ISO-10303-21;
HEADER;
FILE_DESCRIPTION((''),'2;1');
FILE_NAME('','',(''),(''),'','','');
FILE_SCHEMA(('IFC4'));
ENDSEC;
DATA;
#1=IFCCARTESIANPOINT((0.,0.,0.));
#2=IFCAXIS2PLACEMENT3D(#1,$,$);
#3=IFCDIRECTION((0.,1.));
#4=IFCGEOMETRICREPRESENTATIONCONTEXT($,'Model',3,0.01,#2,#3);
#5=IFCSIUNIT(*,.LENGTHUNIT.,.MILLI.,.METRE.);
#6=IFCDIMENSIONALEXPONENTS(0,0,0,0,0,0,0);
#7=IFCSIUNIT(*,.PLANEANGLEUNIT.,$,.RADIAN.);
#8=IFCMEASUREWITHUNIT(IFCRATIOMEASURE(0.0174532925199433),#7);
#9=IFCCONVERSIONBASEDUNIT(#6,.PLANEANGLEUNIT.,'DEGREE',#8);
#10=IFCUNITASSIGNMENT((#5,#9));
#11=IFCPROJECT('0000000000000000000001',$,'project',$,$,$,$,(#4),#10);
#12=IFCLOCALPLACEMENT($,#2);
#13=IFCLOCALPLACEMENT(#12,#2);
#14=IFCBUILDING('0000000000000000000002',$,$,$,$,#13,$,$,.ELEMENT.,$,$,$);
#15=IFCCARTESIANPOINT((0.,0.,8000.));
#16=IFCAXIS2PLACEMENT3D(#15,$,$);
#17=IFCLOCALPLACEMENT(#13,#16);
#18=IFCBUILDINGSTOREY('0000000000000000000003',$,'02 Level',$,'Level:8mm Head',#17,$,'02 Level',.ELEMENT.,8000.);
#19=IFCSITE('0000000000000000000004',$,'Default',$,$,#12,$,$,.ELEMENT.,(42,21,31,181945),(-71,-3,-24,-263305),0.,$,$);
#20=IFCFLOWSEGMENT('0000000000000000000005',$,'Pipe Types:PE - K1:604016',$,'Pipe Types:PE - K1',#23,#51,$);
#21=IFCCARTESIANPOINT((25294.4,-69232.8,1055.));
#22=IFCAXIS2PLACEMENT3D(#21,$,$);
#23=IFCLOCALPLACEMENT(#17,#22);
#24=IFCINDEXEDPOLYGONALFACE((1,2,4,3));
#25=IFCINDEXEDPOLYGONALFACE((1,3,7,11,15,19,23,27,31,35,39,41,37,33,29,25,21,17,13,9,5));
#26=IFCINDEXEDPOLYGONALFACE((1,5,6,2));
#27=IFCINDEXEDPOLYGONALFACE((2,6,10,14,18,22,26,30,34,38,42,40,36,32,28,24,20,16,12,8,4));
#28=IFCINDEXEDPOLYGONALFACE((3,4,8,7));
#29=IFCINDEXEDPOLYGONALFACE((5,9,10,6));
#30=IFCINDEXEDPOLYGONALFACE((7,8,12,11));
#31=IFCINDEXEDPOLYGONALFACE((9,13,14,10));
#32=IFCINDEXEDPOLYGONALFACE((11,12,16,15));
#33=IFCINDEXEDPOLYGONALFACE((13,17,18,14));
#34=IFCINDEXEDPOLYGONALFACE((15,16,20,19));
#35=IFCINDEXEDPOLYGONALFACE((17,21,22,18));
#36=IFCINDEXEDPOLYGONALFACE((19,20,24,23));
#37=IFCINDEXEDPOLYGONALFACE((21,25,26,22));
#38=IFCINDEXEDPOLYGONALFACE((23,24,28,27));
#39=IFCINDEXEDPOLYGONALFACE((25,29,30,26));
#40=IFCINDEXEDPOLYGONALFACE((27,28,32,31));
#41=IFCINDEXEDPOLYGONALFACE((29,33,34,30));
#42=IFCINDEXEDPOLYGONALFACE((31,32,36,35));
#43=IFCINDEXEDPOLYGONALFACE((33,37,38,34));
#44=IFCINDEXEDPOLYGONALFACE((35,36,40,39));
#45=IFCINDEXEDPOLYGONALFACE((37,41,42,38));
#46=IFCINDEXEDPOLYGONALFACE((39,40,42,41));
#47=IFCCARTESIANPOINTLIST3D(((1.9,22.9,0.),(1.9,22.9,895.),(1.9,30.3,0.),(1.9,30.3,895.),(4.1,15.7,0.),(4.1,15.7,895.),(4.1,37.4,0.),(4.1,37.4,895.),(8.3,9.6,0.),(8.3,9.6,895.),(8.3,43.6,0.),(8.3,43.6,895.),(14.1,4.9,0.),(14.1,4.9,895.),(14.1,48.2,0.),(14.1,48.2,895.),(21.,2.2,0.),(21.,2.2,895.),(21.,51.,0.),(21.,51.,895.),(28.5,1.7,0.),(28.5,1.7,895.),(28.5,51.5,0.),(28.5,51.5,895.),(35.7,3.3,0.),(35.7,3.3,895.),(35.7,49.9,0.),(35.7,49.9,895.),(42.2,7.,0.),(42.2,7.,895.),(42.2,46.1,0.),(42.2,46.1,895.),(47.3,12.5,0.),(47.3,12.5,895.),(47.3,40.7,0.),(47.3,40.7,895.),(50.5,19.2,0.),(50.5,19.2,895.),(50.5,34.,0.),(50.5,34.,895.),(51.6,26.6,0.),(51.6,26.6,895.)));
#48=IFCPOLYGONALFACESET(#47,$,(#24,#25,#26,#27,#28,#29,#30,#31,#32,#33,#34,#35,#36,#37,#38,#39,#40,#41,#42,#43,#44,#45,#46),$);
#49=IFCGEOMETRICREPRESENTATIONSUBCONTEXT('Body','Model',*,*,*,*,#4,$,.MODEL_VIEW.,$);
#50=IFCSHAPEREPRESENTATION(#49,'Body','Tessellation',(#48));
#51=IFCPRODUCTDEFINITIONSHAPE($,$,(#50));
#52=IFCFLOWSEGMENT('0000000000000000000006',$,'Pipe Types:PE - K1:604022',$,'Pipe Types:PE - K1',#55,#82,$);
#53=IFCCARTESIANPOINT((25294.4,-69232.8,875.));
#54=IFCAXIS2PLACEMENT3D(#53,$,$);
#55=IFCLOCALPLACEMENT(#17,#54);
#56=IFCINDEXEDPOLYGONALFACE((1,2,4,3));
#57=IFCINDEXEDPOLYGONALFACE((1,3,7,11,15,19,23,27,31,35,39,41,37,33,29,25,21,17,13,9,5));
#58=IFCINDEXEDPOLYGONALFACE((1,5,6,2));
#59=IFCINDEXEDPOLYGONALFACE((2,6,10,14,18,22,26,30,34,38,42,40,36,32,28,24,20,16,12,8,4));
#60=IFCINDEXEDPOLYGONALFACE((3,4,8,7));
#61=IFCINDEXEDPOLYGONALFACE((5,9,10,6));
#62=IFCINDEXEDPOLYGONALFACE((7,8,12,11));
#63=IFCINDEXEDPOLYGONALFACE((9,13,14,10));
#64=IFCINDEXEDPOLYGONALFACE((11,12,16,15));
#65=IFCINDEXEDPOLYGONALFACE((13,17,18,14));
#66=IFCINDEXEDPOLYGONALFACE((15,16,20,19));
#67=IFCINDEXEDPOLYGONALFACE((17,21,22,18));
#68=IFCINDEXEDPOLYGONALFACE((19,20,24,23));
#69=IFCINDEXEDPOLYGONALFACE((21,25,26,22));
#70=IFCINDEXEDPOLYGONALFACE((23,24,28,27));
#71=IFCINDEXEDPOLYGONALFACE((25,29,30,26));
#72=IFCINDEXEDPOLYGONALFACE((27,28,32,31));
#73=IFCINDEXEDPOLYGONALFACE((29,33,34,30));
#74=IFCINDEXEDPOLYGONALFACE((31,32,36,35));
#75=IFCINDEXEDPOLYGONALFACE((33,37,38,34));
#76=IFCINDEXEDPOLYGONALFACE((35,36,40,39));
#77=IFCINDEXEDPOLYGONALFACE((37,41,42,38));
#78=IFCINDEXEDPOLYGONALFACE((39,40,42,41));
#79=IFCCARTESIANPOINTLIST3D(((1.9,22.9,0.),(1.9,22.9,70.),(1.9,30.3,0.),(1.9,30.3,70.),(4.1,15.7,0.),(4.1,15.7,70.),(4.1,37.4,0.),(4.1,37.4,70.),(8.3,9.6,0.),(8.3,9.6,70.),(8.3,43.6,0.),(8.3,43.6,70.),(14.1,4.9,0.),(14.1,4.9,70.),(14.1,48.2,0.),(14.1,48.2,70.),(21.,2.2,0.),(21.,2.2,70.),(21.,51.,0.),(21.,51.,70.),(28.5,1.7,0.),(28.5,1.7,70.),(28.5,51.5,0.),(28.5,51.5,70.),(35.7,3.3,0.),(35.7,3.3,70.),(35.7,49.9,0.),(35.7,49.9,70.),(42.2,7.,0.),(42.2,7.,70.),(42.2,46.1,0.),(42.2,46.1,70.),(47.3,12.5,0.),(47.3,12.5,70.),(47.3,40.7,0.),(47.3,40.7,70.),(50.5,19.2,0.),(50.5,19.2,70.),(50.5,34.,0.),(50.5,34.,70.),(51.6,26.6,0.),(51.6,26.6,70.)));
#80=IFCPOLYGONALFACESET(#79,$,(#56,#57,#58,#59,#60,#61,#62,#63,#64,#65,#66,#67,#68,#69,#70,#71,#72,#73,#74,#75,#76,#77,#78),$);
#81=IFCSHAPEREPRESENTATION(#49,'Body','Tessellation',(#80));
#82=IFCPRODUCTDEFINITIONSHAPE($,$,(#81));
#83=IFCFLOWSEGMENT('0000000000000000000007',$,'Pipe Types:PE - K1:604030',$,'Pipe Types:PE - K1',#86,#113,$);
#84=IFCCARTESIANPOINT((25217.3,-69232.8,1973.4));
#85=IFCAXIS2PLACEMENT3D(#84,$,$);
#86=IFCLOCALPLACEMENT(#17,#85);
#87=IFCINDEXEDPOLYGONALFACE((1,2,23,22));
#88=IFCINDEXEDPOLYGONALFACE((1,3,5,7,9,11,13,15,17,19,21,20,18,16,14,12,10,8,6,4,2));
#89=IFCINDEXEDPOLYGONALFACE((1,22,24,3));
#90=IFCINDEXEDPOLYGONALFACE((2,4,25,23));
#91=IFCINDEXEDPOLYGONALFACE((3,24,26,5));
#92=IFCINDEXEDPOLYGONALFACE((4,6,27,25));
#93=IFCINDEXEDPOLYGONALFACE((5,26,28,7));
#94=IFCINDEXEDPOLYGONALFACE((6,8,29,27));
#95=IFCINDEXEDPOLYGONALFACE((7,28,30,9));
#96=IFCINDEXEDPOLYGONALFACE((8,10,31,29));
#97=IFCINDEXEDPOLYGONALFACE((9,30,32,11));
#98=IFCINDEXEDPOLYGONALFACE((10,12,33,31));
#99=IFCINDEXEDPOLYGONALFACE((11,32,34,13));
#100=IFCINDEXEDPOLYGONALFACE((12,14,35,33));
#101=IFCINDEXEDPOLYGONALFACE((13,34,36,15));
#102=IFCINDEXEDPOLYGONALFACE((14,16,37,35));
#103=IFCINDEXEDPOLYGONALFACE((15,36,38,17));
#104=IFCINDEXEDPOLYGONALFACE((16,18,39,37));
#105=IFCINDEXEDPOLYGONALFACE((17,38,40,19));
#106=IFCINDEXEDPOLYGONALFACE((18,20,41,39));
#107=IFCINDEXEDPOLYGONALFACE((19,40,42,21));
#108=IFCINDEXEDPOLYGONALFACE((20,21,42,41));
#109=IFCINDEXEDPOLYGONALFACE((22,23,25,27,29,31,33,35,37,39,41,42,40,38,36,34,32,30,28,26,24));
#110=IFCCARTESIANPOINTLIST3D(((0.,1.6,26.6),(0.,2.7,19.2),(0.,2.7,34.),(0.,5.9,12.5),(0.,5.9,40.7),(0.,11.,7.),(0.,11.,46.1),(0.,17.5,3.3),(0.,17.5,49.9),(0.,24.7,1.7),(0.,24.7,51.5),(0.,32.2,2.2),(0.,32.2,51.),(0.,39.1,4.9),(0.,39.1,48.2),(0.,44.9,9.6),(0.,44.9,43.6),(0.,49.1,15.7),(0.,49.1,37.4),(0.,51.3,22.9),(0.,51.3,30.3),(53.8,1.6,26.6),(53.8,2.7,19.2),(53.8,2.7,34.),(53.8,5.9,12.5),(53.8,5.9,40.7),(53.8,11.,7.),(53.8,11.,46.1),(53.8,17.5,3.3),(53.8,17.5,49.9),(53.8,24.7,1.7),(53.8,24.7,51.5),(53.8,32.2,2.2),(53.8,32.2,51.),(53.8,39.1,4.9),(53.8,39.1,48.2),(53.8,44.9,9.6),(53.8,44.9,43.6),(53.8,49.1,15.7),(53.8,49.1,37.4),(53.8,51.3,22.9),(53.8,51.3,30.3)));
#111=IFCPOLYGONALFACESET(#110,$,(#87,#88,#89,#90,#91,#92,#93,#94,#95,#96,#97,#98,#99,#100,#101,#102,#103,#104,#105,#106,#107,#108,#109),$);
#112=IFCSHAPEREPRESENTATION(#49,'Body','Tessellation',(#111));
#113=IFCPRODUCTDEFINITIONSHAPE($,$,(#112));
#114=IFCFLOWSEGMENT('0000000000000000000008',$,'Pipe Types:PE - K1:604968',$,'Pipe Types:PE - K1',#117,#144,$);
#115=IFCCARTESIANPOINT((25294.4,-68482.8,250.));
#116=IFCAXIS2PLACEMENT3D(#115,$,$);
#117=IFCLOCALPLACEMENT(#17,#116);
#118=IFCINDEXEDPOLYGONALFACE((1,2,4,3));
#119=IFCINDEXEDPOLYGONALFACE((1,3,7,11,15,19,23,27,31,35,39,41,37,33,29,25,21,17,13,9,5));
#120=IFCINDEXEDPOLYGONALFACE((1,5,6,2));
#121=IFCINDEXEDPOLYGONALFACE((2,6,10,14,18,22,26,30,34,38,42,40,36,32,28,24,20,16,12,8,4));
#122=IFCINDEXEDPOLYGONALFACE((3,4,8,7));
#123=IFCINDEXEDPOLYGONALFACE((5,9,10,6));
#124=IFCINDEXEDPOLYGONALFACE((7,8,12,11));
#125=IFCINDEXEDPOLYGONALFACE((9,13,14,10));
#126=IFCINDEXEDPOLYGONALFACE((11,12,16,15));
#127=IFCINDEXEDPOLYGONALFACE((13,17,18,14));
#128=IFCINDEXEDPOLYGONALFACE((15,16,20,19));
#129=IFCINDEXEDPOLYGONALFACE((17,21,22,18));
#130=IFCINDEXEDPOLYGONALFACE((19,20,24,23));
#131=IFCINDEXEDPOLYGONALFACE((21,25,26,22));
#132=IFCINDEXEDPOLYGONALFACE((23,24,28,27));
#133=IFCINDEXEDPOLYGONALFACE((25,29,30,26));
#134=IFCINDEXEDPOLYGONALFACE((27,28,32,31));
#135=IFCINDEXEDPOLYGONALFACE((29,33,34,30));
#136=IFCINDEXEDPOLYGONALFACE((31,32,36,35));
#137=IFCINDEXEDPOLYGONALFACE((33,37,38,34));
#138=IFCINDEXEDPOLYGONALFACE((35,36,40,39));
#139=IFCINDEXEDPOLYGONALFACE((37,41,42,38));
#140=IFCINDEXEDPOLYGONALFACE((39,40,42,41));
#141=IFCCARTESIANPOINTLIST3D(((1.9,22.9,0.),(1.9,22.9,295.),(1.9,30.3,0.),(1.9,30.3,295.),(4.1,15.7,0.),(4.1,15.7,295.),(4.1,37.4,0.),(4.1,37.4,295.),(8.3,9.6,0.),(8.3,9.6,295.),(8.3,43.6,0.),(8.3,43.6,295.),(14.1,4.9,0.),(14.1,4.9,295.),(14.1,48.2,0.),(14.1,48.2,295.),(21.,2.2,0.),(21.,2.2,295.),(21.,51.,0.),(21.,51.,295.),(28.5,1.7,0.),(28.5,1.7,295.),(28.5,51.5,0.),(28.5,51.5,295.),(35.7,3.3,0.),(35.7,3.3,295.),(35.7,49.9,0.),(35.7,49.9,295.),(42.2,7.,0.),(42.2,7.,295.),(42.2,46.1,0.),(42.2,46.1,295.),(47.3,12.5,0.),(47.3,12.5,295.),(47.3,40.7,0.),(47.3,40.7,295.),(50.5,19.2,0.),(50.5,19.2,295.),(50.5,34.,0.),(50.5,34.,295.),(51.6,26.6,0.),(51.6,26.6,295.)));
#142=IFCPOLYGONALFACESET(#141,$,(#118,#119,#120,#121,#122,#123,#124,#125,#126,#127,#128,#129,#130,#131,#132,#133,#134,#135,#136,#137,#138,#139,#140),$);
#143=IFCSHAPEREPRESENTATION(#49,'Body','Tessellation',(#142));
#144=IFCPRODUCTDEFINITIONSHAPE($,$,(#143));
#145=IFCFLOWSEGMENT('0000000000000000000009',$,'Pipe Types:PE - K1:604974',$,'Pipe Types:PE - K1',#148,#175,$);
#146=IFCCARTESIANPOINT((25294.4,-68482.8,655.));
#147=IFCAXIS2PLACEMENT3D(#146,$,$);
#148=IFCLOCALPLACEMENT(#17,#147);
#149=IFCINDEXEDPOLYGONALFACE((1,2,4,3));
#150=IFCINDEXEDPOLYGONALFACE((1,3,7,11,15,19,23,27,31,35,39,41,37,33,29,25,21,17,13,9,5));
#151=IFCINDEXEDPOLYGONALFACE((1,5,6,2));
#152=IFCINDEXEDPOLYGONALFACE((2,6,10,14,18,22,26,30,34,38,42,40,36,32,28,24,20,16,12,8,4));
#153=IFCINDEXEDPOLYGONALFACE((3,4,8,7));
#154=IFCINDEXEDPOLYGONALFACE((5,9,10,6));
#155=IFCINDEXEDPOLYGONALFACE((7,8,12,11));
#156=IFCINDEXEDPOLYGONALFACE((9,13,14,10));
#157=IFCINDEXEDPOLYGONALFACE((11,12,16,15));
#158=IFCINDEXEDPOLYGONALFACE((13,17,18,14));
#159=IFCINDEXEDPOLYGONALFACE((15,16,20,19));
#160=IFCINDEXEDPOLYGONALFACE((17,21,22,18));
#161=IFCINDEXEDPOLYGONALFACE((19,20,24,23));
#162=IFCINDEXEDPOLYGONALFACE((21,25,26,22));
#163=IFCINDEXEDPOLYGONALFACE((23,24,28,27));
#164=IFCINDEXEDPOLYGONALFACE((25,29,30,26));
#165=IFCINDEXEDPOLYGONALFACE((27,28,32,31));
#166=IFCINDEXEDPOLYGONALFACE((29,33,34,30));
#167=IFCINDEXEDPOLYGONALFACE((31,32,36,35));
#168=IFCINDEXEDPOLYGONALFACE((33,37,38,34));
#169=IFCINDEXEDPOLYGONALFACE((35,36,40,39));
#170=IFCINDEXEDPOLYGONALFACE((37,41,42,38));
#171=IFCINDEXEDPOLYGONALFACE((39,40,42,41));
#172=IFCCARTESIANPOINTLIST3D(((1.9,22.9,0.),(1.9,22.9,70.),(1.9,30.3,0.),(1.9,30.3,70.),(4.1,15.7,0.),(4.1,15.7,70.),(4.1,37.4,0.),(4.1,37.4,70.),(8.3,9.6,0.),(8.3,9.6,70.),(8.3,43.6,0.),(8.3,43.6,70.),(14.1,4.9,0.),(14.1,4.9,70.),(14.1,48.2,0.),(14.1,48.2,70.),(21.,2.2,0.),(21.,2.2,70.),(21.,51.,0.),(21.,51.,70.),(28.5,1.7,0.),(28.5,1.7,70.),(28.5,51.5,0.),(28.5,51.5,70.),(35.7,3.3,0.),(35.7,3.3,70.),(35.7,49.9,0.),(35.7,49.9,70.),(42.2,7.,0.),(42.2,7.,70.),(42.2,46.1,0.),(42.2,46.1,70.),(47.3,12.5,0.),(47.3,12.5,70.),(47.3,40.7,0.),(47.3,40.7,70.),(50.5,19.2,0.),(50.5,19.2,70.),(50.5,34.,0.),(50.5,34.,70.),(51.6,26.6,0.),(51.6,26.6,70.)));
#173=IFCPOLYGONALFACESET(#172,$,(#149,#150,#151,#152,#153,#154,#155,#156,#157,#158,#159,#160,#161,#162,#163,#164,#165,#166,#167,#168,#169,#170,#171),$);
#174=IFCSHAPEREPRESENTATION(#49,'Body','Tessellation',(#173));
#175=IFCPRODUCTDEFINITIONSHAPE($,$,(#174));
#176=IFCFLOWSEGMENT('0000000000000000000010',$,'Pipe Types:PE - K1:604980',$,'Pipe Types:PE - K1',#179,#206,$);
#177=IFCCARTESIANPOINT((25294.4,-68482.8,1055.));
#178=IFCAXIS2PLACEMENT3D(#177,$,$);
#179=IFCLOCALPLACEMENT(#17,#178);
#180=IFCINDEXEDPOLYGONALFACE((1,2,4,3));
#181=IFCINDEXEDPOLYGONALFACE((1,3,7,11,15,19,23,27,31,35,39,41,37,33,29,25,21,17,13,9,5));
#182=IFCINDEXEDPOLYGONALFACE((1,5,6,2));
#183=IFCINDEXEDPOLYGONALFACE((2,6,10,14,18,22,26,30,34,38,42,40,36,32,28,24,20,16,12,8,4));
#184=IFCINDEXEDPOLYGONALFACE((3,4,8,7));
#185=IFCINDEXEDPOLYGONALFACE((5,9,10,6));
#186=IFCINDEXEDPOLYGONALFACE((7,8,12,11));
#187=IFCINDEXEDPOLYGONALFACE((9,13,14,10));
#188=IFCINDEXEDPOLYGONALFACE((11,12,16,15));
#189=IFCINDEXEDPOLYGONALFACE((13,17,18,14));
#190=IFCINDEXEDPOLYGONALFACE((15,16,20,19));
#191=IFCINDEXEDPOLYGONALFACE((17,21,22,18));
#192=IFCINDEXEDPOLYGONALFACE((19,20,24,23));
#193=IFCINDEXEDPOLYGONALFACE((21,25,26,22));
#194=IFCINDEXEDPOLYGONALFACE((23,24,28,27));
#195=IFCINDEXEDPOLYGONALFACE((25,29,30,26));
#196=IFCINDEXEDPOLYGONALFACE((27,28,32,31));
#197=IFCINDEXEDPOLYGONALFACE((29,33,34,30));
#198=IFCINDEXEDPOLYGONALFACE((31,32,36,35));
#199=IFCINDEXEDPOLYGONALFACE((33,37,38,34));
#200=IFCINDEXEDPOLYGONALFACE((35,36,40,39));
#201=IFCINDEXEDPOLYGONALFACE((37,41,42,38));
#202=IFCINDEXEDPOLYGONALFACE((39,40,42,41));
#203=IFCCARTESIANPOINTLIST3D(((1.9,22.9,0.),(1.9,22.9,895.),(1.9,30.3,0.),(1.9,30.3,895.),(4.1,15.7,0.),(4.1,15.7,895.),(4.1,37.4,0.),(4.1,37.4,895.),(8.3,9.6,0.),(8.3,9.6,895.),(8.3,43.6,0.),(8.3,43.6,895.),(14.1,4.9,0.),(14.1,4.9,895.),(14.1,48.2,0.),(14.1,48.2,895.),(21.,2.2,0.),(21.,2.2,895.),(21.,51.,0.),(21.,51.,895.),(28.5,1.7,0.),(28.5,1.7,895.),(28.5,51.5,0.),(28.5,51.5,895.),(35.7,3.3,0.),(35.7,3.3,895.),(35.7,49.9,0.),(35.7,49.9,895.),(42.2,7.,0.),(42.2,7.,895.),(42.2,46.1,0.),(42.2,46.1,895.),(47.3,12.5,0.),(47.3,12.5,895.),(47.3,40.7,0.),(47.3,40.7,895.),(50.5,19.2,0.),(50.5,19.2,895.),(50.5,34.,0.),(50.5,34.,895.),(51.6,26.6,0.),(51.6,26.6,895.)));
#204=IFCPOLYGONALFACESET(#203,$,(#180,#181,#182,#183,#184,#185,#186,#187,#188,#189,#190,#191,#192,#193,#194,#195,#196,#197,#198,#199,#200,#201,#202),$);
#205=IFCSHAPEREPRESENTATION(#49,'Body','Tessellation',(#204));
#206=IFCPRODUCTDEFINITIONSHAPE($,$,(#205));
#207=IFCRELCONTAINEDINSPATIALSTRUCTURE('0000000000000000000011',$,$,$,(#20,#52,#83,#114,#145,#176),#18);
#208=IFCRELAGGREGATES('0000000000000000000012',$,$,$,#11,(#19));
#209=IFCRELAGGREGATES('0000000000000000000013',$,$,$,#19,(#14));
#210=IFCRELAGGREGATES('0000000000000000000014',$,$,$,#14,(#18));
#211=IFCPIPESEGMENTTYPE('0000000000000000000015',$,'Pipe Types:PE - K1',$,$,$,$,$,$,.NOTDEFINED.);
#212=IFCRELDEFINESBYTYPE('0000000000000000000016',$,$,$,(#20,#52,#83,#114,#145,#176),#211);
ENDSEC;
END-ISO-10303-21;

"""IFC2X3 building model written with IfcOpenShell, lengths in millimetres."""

from ifc_helpers import new_model, entity, si_unit, converted_unit, direction, frame, frame_2d, origin, origin_2d_with_axis, place, context, subcontext, project, spatial, circle, extrude, type_object, element, save


model = new_model("IFC2X3")

# Units and contexts
model_context = context("Model", 3, precision=0.01, world=origin(), true_north=direction((0.0, 1.0)))
body_context = subcontext(model_context, "Body", "Model", "MODEL_VIEW")
ifc_project = project(units=[si_unit("LENGTHUNIT", "METRE", prefix="MILLI"), converted_unit("PLANEANGLEUNIT", "DEGREE", entity("IfcRatioMeasure", 0.0174532925199433), si_unit("PLANEANGLEUNIT", "RADIAN"), dimensions=[0, 0, 0, 0, 0, 0, 0])], contexts=[model_context])

# Site, building, storey
site_placement = place(None, origin())
site = spatial("IfcSite", under=ifc_project, at=site_placement, Name="Default", CompositionType="ELEMENT", RefLatitude=(42, 21, 31, 181945), RefLongitude=(-71, -3, -24, -263305), RefElevation=0.0)
building_placement = place(site_placement, origin())
building = spatial("IfcBuilding", under=site, at=building_placement, CompositionType="ELEMENT")
storey_placement = place(building_placement, frame((0.0, 0.0, 8000.0)))
storey = spatial("IfcBuildingStorey", under=building, at=storey_placement, Name="02 Level", ObjectType="Level:8mm Head", LongName="02 Level", CompositionType="ELEMENT", Elevation=8000.0)

# Flow segments
pipe_segment_type_1 = type_object("IfcPipeSegmentType", Name="Pipe Types:PE - K1", PredefinedType="NOTDEFINED")
flow_segment_1_placement = place(storey_placement, frame((25294.4, -69232.8, 1055.0)))
element("IfcFlowSegment", 1, at=flow_segment_1_placement, inside=storey, type_object=pipe_segment_type_1, Name="Pipe Types:PE - K1:604016", ObjectType="Pipe Types:PE - K1", context=body_context, shape_type="SweptSolid", body=[
    extrude(circle(Radius=25.0, at=origin_2d_with_axis()), frame((26.6, 26.6, 0.0)), (0.0, 0.0, 1.0), 895.0),
])
flow_segment_2_placement = place(storey_placement, frame((25294.4, -69232.8, 875.0)))
element("IfcFlowSegment", 2, at=flow_segment_2_placement, inside=storey, type_object=pipe_segment_type_1, Name="Pipe Types:PE - K1:604022", ObjectType="Pipe Types:PE - K1", context=body_context, shape_type="SweptSolid", body=[
    extrude(circle(Radius=25.0, at=origin_2d_with_axis()), frame((26.6, 26.6, 0.0)), (0.0, 0.0, 1.0), 70.0),
])
flow_segment_3_placement = place(storey_placement, frame((25217.3, -69232.8, 1973.4)))
element("IfcFlowSegment", 3, at=flow_segment_3_placement, inside=storey, type_object=pipe_segment_type_1, Name="Pipe Types:PE - K1:604030", ObjectType="Pipe Types:PE - K1", context=body_context, shape_type="SweptSolid", body=[
    extrude(circle(Radius=25.0, at=frame_2d((0.0, 0.0), x_axis=(1.0, 0.0))), frame((0.0, 26.6, 26.6), z_axis=(1.0, 0.0, 0.0), x_axis=(0.0, -1.0, 0.0)), (0.0, 0.0, 1.0), 53.8),
])
flow_segment_4_placement = place(storey_placement, frame((25294.4, -68482.8, 250.0)))
element("IfcFlowSegment", 4, at=flow_segment_4_placement, inside=storey, type_object=pipe_segment_type_1, Name="Pipe Types:PE - K1:604968", ObjectType="Pipe Types:PE - K1", context=body_context, shape_type="SweptSolid", body=[
    extrude(circle(Radius=25.0, at=origin_2d_with_axis()), frame((26.6, 26.6, 0.0)), (0.0, 0.0, 1.0), 295.0),
])
flow_segment_5_placement = place(storey_placement, frame((25294.4, -68482.8, 655.0)))
element("IfcFlowSegment", 5, at=flow_segment_5_placement, inside=storey, type_object=pipe_segment_type_1, Name="Pipe Types:PE - K1:604974", ObjectType="Pipe Types:PE - K1", context=body_context, shape_type="SweptSolid", body=[
    extrude(circle(Radius=25.0, at=origin_2d_with_axis()), frame((26.6, 26.6, 0.0)), (0.0, 0.0, 1.0), 70.0),
])
flow_segment_6_placement = place(storey_placement, frame((25294.4, -68482.8, 1055.0)))
element("IfcFlowSegment", 6, at=flow_segment_6_placement, inside=storey, type_object=pipe_segment_type_1, Name="Pipe Types:PE - K1:604980", ObjectType="Pipe Types:PE - K1", context=body_context, shape_type="SweptSolid", body=[
    extrude(circle(Radius=25.0, at=frame_2d((0.0, 0.0), x_axis=(1.0, 0.0))), frame((26.6, 26.6, 0.0)), (0.0, 0.0, 1.0), 895.0),
])

save(model, "model.ifc")
